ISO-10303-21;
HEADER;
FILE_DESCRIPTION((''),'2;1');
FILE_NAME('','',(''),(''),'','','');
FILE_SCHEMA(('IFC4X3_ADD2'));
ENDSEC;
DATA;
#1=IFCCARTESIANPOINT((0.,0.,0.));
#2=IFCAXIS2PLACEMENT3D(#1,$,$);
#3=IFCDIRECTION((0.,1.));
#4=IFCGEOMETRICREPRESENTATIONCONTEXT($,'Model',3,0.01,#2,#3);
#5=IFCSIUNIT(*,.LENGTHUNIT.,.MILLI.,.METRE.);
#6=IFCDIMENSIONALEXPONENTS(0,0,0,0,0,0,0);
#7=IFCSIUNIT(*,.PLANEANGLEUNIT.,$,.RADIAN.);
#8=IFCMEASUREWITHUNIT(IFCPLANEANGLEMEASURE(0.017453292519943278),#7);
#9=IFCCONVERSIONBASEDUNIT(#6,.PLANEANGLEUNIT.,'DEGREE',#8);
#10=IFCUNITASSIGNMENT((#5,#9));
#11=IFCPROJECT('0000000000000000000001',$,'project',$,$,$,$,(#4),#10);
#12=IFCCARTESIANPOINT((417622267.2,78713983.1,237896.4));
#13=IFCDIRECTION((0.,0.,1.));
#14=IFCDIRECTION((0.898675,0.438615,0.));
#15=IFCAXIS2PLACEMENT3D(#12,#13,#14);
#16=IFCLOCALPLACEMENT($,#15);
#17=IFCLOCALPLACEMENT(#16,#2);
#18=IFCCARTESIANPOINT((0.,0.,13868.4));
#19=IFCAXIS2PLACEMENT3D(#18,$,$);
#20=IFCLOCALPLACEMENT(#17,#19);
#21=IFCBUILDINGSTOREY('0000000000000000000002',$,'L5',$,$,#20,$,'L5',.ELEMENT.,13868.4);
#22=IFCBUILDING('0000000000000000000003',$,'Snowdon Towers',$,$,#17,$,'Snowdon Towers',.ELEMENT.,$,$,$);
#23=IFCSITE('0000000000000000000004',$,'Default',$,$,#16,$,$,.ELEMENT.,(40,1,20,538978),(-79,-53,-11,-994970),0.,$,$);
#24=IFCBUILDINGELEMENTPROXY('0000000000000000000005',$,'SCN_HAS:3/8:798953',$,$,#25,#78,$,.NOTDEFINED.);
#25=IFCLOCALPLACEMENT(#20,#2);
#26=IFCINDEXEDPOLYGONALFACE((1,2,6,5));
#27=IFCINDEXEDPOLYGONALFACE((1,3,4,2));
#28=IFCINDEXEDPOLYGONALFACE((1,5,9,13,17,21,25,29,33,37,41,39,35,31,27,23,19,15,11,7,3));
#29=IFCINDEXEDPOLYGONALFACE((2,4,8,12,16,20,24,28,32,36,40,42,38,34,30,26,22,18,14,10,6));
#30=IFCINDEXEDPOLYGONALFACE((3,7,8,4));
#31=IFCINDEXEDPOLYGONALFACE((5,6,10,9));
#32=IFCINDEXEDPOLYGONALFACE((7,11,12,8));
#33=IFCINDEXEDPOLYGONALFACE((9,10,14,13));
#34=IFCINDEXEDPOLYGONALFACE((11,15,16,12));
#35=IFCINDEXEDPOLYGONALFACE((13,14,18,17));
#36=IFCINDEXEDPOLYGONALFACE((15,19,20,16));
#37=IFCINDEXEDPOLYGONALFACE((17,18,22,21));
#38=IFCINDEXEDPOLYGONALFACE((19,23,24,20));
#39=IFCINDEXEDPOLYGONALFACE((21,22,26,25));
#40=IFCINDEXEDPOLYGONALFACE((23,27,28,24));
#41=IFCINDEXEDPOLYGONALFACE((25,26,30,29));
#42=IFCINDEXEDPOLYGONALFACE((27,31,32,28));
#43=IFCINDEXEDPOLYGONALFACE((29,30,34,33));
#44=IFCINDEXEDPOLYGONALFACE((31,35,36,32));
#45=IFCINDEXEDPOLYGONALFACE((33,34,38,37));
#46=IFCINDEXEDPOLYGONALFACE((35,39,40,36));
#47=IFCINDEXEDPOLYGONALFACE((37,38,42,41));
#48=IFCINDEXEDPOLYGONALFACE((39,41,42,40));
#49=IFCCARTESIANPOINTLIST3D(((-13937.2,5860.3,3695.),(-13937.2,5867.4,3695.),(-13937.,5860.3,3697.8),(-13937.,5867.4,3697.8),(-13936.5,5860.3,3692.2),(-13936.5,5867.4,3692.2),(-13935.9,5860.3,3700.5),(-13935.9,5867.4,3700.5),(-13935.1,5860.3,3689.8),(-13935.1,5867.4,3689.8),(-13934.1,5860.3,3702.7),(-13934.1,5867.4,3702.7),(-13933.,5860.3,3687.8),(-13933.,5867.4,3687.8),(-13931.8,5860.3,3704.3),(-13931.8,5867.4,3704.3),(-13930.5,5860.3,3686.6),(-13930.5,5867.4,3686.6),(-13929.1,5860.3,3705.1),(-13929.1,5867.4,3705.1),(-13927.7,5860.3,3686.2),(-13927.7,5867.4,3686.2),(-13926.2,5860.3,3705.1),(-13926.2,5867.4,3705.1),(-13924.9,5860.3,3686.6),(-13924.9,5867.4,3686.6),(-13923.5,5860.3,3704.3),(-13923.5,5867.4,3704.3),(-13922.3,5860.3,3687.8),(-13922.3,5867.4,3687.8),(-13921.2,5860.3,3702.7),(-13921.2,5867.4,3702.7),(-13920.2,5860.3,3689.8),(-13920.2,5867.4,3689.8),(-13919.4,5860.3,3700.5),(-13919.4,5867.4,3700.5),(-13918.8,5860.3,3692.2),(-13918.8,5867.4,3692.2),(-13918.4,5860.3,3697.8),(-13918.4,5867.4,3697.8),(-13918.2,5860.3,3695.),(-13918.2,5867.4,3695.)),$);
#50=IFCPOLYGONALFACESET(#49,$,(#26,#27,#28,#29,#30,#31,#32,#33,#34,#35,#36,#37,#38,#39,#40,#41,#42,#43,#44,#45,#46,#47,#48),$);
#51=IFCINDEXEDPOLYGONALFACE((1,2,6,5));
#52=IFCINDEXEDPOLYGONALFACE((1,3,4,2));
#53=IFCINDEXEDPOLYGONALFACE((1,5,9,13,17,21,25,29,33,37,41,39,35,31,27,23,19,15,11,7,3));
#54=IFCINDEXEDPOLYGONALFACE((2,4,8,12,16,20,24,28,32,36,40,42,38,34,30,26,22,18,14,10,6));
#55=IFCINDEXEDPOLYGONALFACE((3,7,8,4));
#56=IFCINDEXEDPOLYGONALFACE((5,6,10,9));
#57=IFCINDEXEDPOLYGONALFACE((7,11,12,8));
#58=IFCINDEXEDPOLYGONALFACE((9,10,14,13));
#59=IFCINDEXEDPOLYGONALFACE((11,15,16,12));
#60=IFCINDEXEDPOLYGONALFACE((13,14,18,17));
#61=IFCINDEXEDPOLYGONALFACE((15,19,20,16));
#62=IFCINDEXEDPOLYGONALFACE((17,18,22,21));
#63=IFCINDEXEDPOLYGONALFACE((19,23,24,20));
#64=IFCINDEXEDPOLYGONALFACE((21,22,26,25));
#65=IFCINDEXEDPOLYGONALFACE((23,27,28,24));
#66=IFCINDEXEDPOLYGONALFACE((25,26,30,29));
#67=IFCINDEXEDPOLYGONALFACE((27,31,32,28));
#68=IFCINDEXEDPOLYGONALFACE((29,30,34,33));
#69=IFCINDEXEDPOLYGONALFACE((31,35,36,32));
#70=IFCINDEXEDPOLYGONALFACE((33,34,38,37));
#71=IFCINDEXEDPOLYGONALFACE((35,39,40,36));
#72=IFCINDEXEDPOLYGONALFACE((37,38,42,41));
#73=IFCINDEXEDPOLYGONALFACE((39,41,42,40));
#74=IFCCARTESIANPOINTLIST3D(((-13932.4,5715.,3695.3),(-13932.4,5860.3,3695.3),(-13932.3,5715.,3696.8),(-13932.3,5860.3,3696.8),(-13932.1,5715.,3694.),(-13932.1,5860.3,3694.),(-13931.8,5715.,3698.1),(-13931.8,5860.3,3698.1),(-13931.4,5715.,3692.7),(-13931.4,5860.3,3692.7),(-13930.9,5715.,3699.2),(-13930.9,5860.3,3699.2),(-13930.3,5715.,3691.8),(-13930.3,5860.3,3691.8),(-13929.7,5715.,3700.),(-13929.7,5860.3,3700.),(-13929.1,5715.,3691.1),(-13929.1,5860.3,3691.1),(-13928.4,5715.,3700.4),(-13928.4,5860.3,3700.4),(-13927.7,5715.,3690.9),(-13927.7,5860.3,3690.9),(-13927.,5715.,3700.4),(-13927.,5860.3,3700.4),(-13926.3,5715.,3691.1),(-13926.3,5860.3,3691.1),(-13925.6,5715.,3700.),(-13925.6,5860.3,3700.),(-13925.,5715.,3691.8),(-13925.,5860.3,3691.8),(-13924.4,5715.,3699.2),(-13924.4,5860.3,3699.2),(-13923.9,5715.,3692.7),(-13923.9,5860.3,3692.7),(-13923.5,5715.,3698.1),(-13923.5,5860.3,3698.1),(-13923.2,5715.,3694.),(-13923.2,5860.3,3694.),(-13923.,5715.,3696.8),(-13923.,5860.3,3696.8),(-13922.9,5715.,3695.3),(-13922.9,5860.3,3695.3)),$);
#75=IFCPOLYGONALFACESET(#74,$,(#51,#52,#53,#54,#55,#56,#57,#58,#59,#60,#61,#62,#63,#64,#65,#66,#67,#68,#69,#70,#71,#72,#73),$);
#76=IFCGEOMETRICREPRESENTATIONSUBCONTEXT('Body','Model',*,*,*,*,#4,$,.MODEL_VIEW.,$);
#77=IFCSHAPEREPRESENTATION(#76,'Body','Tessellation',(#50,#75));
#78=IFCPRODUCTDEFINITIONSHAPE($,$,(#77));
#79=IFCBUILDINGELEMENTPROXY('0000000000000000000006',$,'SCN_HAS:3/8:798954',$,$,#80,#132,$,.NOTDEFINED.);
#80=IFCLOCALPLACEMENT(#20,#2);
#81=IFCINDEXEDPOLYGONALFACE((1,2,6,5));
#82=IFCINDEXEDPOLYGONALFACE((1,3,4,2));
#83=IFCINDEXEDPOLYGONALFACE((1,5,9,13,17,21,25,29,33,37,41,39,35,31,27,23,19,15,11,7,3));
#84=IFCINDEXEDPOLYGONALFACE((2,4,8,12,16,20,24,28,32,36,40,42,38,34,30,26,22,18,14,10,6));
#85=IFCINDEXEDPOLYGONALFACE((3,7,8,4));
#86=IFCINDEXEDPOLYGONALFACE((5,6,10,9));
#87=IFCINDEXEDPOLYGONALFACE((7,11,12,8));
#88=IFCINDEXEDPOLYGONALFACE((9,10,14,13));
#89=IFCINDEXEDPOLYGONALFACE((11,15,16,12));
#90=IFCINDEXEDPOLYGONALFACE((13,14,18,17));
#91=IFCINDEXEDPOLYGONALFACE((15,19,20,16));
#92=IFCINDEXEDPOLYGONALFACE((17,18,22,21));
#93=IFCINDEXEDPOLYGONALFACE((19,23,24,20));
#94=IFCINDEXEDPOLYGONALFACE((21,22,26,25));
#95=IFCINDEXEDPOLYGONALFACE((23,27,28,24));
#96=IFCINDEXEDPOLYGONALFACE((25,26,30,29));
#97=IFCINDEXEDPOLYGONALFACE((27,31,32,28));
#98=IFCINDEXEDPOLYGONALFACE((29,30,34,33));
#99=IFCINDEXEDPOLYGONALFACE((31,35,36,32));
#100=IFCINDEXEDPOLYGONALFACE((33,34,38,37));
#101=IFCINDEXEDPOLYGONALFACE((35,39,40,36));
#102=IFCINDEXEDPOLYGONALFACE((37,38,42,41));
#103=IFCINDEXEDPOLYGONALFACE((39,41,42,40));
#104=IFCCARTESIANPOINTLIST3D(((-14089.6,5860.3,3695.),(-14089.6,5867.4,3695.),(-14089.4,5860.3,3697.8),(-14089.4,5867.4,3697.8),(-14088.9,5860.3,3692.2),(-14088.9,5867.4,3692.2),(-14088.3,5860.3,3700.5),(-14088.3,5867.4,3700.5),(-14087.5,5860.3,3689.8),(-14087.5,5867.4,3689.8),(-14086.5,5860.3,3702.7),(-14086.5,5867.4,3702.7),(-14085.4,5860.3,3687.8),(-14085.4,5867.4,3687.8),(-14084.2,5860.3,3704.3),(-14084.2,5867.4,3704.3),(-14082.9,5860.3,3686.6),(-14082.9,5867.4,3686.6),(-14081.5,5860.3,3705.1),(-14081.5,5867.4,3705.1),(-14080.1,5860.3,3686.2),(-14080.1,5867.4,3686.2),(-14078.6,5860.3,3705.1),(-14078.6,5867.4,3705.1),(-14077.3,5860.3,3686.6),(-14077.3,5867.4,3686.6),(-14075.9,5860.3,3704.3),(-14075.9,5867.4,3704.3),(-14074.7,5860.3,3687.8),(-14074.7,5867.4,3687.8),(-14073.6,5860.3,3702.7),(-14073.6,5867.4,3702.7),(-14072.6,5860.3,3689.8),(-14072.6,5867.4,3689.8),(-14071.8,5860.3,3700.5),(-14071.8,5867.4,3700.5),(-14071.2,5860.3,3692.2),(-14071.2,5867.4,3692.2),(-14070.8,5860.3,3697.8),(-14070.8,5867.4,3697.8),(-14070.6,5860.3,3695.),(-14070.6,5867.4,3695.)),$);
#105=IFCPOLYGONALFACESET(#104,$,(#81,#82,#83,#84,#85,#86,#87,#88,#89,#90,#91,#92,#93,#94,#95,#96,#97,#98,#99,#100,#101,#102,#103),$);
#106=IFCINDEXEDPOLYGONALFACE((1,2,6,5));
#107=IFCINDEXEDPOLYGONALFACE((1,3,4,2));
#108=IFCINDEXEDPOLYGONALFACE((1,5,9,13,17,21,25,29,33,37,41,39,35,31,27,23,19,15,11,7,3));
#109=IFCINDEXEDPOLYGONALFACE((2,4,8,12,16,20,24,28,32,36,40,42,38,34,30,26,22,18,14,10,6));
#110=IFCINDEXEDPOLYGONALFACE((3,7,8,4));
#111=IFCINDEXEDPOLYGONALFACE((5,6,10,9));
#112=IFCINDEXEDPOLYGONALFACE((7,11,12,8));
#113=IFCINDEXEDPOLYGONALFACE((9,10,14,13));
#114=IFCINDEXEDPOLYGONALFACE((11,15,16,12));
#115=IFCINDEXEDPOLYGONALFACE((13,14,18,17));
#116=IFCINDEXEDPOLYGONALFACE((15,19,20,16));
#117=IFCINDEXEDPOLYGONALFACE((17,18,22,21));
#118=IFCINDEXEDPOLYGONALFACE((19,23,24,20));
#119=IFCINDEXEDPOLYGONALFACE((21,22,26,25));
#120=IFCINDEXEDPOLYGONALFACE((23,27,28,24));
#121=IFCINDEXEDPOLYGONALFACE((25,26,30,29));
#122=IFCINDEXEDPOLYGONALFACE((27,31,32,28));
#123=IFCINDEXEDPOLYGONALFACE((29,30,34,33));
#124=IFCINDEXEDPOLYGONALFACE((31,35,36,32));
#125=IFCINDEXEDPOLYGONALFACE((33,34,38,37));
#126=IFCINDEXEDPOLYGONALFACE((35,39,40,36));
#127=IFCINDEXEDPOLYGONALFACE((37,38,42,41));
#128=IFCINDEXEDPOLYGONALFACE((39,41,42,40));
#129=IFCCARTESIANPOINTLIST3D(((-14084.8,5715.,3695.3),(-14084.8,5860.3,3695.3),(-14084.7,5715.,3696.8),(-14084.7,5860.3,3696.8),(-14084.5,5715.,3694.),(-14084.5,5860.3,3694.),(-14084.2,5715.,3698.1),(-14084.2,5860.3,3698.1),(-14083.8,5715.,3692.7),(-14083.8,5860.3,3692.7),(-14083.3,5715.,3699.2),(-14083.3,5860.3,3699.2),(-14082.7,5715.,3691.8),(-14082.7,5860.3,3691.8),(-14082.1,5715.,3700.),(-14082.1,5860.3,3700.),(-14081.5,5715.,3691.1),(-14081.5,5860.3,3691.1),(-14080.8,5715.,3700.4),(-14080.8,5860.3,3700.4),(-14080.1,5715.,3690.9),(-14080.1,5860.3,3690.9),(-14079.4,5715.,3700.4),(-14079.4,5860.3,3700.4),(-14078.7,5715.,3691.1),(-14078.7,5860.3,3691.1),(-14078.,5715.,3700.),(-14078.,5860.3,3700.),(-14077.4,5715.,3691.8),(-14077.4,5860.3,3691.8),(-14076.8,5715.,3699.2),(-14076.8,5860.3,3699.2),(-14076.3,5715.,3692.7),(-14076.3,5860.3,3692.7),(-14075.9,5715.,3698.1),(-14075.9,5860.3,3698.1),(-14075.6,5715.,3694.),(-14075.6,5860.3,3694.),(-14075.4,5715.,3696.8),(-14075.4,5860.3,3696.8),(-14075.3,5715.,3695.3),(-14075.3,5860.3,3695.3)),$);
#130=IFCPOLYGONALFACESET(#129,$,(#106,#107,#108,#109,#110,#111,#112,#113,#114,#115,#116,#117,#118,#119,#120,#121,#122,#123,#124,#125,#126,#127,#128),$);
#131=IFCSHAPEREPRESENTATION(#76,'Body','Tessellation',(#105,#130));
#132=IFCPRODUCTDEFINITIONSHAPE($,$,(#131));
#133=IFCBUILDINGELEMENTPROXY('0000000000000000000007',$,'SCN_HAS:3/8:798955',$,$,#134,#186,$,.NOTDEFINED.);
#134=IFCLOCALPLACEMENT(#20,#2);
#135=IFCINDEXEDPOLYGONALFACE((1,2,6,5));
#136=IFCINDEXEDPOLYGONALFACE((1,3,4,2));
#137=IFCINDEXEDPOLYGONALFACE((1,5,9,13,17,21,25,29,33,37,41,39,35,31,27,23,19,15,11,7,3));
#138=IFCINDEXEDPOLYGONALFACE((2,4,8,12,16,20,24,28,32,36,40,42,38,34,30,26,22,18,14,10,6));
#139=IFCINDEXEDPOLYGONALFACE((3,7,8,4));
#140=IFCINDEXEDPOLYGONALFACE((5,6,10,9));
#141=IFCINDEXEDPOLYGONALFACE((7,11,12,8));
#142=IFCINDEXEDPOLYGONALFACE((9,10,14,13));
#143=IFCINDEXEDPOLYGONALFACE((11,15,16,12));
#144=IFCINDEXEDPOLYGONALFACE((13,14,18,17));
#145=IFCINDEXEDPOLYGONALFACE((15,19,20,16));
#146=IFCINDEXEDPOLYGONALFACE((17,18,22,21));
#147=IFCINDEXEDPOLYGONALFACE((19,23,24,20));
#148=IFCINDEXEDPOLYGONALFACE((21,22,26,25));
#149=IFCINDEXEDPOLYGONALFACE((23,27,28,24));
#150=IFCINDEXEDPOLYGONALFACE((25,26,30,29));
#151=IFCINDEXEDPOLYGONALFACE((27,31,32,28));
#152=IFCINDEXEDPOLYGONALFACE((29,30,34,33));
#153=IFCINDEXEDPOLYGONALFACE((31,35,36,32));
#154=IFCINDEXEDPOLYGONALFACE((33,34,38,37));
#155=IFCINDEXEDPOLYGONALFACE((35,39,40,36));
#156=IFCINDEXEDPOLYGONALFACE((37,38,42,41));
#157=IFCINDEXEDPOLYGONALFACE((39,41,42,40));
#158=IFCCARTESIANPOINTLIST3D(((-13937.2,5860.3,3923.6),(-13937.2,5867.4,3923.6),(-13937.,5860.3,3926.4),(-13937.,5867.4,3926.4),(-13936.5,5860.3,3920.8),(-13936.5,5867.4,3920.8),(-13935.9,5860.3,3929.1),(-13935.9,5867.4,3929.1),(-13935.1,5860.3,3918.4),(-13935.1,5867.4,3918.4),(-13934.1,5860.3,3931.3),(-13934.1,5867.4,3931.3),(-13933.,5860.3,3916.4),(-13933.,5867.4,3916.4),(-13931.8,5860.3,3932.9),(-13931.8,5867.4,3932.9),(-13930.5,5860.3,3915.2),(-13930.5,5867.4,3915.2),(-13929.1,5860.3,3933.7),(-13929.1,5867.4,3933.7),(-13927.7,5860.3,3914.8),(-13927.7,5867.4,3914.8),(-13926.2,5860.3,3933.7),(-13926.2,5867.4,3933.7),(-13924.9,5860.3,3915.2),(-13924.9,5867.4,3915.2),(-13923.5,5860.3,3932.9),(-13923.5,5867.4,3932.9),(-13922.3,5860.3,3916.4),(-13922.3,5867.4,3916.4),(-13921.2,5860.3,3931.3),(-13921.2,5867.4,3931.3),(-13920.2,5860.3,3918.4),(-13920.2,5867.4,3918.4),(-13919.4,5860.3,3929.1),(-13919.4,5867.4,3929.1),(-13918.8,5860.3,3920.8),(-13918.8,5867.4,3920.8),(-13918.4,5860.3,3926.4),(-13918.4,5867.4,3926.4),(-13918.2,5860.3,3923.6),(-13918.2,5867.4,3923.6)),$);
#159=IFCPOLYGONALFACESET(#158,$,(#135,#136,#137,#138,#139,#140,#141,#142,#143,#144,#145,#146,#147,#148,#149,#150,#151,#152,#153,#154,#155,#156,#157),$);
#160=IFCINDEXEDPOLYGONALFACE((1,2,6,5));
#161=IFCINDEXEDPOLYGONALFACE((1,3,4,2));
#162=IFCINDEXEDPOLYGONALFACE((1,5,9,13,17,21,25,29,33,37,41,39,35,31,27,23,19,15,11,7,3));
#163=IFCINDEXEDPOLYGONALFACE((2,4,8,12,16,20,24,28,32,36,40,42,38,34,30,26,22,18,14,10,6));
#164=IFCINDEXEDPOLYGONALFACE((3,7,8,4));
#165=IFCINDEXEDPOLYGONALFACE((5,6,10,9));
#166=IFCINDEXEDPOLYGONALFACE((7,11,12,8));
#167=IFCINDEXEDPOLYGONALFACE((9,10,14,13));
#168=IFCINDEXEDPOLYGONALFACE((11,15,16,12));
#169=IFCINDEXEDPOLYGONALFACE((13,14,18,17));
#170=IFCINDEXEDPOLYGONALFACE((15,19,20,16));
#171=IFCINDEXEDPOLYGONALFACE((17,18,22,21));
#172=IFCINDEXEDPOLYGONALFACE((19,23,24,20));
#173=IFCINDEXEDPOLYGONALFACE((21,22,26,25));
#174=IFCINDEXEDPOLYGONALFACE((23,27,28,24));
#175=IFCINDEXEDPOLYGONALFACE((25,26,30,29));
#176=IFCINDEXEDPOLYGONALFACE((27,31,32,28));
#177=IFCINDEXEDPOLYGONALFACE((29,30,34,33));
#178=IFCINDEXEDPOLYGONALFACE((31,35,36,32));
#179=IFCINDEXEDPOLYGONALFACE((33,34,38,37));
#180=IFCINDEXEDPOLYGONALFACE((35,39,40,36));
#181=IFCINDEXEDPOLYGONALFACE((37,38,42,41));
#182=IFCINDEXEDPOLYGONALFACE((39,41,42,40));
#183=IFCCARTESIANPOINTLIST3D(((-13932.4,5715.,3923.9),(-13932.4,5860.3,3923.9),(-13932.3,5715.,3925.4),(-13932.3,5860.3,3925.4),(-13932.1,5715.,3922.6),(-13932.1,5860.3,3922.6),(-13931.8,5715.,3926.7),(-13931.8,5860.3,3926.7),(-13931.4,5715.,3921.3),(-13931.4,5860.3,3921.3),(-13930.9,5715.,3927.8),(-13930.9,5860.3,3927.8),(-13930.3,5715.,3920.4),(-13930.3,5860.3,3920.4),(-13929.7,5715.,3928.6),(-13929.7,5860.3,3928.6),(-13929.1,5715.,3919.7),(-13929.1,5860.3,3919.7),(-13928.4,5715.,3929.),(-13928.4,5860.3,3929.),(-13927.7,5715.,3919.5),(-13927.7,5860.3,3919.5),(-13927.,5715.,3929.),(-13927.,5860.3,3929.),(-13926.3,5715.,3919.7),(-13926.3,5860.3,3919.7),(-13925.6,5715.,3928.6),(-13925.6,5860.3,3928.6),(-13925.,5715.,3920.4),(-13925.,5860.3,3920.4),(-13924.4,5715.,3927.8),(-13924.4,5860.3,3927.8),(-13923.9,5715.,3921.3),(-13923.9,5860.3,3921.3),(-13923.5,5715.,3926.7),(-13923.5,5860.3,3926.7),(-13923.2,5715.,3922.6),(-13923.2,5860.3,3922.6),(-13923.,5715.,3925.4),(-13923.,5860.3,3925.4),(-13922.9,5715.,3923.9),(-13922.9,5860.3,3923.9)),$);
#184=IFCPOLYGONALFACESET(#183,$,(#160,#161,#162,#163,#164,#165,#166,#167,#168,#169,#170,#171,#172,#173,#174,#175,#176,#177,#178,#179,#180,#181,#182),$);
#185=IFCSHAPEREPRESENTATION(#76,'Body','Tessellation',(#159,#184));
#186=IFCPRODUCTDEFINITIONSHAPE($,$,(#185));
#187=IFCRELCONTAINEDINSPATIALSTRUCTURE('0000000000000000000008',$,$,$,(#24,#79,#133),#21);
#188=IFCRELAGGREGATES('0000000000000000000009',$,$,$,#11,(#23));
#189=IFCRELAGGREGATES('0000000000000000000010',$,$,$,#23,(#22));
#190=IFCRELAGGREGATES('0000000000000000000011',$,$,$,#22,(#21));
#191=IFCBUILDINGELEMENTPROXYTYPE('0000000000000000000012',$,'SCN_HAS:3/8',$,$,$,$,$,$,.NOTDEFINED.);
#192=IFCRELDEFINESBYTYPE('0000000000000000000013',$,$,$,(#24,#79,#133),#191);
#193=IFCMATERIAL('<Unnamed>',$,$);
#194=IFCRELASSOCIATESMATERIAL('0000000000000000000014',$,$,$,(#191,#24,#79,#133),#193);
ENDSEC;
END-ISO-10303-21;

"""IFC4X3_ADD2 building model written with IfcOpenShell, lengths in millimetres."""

from ifc_helpers import new_model, entity, si_unit, converted_unit, direction, frame, frame_2d, origin, place, context, subcontext, project, spatial, circle, extrude, source, transform, mapped, material, type_object, type_shapes, element, save


model = new_model("IFC4X3_ADD2")

# Units and contexts
model_context = context("Model", 3, precision=0.01, world=origin(), true_north=direction((0.0, 1.0)))
body_context = subcontext(model_context, "Body", "Model", "MODEL_VIEW")
ifc_project = project(units=[si_unit("LENGTHUNIT", "METRE", prefix="MILLI"), converted_unit("PLANEANGLEUNIT", "DEGREE", entity("IfcPlaneAngleMeasure", 0.017453292519943278), si_unit("PLANEANGLEUNIT", "RADIAN"), dimensions=[0, 0, 0, 0, 0, 0, 0])], contexts=[model_context])

# Site, building, storey
site_placement = place(None, frame((417622267.2, 78713983.1, 237896.4), z_axis=(0.0, 0.0, 1.0), x_axis=(0.898675, 0.438615, 0.0)))
site = spatial("IfcSite", under=ifc_project, at=site_placement, Name="Default", CompositionType="ELEMENT", RefLatitude=(40, 1, 20, 538978), RefLongitude=(-79, -53, -11, -994970), RefElevation=0.0)
building_placement = place(site_placement, origin())
building = spatial("IfcBuilding", under=site, at=building_placement, Name="Snowdon Towers", LongName="Snowdon Towers", CompositionType="ELEMENT")
storey_placement = place(building_placement, frame((0.0, 0.0, 13868.4)))
storey = spatial("IfcBuildingStorey", under=building, at=storey_placement, Name="L5", LongName="L5", CompositionType="ELEMENT", Elevation=13868.4)

# Building element proxies
ifc_material_1 = material(Name="<Unnamed>")
building_element_proxy_type = type_object("IfcBuildingElementProxyType", Name="SCN_HAS:3/8", PredefinedType="NOTDEFINED", material=ifc_material_1)
shared_shape_1 = source(origin(), body_context, "Body", "SweptSolid", [
    extrude(circle(Radius=9.5, at=frame_2d((0.0, 0.0), x_axis=(1.0, 0.0))), frame((0.0, 0.0, -152.4), z_axis=(0.0, 0.0, 1.0), x_axis=(0.0, -1.0, 0.0)), (0.0, 0.0, 1.0), 7.1),
    extrude(circle(Radius=4.8, at=frame_2d((0.0, 0.0), x_axis=(1.0, 0.0))), frame((0.0, 0.0, -145.3), z_axis=(0.0, 0.0, 1.0), x_axis=(0.0, -1.0, 0.0)), (0.0, 0.0, 1.0), 145.3),
])
type_shapes(building_element_proxy_type, [shared_shape_1])
for number, where, z_axis, x_axis, name in (
    (1, (-13927.7, 5715.0, 3695.7), (0.0, -1.0, 0.0), (1.0, 0.0, 0.0), "SCN_HAS:3/8:798953"),
    (2, (-14080.1, 5715.0, 3695.7), (0.0, -1.0, 0.0), (1.0, 0.0, 0.0), "SCN_HAS:3/8:798954"),
    (3, (-13927.7, 5715.0, 3924.3), (0.0, -1.0, 0.0), (1.0, 0.0, 0.0), "SCN_HAS:3/8:798955"),
):
    element("IfcBuildingElementProxy", number, at=place(storey_placement, frame(where, z_axis=z_axis, x_axis=x_axis)), inside=storey, type_object=building_element_proxy_type, material=ifc_material_1, Name=name, PredefinedType="NOTDEFINED", context=body_context, shape_type="MappedRepresentation", body=[
        mapped(shared_shape_1, transform((0.0, 0.0, 0.0), scale=1.0)),
    ])

save(model, "model.ifc")
